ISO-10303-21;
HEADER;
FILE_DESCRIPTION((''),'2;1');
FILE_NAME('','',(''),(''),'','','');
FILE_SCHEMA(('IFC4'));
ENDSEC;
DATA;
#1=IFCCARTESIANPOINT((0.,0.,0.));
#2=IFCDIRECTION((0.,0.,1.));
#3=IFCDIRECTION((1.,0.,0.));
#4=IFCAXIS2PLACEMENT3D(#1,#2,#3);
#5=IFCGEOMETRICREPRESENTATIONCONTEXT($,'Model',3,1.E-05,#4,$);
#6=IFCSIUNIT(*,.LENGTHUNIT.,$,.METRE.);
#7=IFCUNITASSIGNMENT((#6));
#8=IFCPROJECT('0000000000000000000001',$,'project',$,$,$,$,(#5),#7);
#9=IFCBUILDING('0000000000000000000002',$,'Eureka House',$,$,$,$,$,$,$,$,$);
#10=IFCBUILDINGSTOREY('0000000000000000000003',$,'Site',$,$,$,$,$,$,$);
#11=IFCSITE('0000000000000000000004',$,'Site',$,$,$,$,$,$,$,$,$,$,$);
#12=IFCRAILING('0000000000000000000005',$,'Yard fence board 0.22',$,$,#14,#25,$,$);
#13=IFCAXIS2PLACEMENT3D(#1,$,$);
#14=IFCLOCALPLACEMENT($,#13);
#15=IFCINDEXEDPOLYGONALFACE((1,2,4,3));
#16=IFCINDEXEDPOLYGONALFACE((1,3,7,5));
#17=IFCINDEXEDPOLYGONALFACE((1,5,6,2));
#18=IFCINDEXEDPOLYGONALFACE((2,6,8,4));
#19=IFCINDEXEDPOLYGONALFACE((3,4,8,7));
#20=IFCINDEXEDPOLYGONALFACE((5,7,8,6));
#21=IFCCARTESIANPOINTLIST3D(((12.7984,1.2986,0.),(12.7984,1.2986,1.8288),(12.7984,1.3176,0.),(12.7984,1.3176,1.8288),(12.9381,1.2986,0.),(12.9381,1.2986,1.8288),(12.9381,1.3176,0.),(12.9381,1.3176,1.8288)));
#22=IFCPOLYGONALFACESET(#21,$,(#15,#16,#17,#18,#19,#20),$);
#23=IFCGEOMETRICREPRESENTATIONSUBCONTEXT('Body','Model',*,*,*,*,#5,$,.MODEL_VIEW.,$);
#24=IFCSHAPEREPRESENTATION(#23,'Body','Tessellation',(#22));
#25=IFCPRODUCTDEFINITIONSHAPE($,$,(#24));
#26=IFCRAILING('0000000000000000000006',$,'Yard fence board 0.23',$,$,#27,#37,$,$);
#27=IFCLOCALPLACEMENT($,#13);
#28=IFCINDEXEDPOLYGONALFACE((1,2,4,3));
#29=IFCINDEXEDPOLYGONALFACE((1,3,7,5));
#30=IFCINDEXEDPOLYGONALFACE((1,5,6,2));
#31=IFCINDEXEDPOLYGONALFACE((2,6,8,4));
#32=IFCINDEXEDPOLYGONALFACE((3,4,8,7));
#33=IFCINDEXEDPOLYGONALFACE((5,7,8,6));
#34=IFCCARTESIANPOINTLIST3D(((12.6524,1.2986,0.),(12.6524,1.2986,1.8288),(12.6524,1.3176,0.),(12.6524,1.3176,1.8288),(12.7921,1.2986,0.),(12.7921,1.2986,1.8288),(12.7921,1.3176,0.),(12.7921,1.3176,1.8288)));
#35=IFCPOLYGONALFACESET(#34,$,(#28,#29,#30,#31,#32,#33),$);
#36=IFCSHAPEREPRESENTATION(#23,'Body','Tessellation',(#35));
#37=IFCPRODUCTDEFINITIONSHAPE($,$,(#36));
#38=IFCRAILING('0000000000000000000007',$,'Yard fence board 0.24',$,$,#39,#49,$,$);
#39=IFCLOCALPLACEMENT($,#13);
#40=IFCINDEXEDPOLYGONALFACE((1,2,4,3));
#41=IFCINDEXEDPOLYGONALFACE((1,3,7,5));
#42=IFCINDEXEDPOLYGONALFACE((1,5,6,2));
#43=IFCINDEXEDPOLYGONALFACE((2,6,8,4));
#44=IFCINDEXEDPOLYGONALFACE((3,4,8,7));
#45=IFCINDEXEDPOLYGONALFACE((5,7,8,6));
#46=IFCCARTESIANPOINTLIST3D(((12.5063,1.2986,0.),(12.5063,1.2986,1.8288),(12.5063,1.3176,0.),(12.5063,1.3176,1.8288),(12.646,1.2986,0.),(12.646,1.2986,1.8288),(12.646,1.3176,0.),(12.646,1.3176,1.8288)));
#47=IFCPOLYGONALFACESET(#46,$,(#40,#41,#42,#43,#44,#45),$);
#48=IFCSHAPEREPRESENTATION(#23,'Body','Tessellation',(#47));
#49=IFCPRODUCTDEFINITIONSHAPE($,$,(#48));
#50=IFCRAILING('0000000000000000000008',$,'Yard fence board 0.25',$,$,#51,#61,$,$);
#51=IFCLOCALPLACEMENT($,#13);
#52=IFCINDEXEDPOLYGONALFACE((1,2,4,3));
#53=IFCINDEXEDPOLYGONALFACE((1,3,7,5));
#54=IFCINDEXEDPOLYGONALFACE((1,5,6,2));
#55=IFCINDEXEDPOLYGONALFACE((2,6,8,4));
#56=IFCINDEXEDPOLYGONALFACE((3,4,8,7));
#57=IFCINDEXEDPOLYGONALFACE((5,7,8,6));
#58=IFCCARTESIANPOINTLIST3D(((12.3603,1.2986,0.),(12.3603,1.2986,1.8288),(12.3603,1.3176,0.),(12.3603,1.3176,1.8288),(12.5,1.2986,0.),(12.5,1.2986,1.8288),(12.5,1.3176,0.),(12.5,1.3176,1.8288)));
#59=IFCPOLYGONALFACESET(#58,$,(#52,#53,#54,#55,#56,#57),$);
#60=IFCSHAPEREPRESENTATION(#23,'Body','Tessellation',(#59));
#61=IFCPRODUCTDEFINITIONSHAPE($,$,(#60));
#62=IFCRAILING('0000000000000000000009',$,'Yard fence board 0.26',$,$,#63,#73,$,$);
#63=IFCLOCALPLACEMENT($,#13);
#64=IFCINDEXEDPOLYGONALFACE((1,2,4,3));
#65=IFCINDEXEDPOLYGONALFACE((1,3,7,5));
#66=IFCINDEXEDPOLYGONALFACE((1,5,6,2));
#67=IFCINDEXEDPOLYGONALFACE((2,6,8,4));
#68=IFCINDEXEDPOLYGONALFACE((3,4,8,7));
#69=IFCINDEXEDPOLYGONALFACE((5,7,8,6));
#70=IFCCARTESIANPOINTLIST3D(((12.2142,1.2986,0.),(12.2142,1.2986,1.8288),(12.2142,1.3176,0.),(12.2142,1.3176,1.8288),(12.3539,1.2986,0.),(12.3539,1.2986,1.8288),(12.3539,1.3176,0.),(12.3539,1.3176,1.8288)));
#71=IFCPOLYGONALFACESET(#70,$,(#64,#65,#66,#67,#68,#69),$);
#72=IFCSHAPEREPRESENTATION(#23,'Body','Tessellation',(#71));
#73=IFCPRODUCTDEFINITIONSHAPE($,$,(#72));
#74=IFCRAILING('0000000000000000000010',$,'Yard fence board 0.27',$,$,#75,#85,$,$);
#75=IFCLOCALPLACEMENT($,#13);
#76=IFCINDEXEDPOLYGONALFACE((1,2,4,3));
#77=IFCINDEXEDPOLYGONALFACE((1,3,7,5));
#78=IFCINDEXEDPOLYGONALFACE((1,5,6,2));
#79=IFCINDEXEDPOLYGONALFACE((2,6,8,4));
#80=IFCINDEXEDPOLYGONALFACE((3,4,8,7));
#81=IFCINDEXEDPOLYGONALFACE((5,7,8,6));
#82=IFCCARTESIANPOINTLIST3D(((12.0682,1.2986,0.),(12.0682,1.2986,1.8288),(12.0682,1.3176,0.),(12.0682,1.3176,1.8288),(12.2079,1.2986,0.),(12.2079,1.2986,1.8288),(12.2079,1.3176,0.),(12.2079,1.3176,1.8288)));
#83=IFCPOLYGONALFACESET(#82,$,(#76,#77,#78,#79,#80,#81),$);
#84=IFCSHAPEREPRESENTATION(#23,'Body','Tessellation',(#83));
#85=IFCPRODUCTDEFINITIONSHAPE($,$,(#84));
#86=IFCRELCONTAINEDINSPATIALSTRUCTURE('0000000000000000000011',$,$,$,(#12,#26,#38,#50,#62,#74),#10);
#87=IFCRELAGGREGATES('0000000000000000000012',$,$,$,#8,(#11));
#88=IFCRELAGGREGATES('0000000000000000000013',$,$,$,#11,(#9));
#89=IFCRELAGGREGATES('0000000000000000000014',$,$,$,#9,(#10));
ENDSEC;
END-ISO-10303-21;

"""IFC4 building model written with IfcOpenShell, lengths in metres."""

from ifc_helpers import new_model, si_unit, frame, origin, origin_with_axes, origin_2d, place, context, subcontext, project, spatial, rectangle, extrude, element, save


model = new_model("IFC4")

# Units and contexts
model_context = context("Model", 3, precision=1e-05, world=origin_with_axes())
body_context = subcontext(model_context, "Body", "Model", "MODEL_VIEW")
ifc_project = project(units=[si_unit("LENGTHUNIT", "METRE")], contexts=[model_context])

# Site, building, storey
site = spatial("IfcSite", under=ifc_project, Name="Site")
building = spatial("IfcBuilding", under=site, Name="Eureka House")
storey = spatial("IfcBuildingStorey", under=building, Name="Site")

# Railings
for number, where, z_axis, x_axis, name in (
    (1, (12.8683, 1.3081, 0.0), (0.0, 0.0, 1.0), (1.0, 0.0, 0.0), "Yard fence board 0.22"),
    (2, (12.7222, 1.3081, 0.0), (0.0, 0.0, 1.0), (1.0, 0.0, 0.0), "Yard fence board 0.23"),
    (3, (12.5762, 1.3081, 0.0), (0.0, 0.0, 1.0), (1.0, 0.0, 0.0), "Yard fence board 0.24"),
    (4, (12.4301, 1.3081, 0.0), (0.0, 0.0, 1.0), (1.0, 0.0, 0.0), "Yard fence board 0.25"),
    (5, (12.2841, 1.3081, 0.0), (0.0, 0.0, 1.0), (1.0, 0.0, 0.0), "Yard fence board 0.26"),
    (6, (12.138, 1.3081, 0.0), (0.0, 0.0, 1.0), (1.0, 0.0, 0.0), "Yard fence board 0.27"),
):
    element("IfcRailing", number, at=place(None, frame(where, z_axis=z_axis, x_axis=x_axis)), inside=storey, Name=name, context=body_context, shape_type="SweptSolid", body=[
        extrude(rectangle(XDim=0.1397, YDim=0.0191, at=origin_2d()), origin(), (0.0, 0.0, 1.0), 1.8288),
    ])

save(model, "model.ifc")
